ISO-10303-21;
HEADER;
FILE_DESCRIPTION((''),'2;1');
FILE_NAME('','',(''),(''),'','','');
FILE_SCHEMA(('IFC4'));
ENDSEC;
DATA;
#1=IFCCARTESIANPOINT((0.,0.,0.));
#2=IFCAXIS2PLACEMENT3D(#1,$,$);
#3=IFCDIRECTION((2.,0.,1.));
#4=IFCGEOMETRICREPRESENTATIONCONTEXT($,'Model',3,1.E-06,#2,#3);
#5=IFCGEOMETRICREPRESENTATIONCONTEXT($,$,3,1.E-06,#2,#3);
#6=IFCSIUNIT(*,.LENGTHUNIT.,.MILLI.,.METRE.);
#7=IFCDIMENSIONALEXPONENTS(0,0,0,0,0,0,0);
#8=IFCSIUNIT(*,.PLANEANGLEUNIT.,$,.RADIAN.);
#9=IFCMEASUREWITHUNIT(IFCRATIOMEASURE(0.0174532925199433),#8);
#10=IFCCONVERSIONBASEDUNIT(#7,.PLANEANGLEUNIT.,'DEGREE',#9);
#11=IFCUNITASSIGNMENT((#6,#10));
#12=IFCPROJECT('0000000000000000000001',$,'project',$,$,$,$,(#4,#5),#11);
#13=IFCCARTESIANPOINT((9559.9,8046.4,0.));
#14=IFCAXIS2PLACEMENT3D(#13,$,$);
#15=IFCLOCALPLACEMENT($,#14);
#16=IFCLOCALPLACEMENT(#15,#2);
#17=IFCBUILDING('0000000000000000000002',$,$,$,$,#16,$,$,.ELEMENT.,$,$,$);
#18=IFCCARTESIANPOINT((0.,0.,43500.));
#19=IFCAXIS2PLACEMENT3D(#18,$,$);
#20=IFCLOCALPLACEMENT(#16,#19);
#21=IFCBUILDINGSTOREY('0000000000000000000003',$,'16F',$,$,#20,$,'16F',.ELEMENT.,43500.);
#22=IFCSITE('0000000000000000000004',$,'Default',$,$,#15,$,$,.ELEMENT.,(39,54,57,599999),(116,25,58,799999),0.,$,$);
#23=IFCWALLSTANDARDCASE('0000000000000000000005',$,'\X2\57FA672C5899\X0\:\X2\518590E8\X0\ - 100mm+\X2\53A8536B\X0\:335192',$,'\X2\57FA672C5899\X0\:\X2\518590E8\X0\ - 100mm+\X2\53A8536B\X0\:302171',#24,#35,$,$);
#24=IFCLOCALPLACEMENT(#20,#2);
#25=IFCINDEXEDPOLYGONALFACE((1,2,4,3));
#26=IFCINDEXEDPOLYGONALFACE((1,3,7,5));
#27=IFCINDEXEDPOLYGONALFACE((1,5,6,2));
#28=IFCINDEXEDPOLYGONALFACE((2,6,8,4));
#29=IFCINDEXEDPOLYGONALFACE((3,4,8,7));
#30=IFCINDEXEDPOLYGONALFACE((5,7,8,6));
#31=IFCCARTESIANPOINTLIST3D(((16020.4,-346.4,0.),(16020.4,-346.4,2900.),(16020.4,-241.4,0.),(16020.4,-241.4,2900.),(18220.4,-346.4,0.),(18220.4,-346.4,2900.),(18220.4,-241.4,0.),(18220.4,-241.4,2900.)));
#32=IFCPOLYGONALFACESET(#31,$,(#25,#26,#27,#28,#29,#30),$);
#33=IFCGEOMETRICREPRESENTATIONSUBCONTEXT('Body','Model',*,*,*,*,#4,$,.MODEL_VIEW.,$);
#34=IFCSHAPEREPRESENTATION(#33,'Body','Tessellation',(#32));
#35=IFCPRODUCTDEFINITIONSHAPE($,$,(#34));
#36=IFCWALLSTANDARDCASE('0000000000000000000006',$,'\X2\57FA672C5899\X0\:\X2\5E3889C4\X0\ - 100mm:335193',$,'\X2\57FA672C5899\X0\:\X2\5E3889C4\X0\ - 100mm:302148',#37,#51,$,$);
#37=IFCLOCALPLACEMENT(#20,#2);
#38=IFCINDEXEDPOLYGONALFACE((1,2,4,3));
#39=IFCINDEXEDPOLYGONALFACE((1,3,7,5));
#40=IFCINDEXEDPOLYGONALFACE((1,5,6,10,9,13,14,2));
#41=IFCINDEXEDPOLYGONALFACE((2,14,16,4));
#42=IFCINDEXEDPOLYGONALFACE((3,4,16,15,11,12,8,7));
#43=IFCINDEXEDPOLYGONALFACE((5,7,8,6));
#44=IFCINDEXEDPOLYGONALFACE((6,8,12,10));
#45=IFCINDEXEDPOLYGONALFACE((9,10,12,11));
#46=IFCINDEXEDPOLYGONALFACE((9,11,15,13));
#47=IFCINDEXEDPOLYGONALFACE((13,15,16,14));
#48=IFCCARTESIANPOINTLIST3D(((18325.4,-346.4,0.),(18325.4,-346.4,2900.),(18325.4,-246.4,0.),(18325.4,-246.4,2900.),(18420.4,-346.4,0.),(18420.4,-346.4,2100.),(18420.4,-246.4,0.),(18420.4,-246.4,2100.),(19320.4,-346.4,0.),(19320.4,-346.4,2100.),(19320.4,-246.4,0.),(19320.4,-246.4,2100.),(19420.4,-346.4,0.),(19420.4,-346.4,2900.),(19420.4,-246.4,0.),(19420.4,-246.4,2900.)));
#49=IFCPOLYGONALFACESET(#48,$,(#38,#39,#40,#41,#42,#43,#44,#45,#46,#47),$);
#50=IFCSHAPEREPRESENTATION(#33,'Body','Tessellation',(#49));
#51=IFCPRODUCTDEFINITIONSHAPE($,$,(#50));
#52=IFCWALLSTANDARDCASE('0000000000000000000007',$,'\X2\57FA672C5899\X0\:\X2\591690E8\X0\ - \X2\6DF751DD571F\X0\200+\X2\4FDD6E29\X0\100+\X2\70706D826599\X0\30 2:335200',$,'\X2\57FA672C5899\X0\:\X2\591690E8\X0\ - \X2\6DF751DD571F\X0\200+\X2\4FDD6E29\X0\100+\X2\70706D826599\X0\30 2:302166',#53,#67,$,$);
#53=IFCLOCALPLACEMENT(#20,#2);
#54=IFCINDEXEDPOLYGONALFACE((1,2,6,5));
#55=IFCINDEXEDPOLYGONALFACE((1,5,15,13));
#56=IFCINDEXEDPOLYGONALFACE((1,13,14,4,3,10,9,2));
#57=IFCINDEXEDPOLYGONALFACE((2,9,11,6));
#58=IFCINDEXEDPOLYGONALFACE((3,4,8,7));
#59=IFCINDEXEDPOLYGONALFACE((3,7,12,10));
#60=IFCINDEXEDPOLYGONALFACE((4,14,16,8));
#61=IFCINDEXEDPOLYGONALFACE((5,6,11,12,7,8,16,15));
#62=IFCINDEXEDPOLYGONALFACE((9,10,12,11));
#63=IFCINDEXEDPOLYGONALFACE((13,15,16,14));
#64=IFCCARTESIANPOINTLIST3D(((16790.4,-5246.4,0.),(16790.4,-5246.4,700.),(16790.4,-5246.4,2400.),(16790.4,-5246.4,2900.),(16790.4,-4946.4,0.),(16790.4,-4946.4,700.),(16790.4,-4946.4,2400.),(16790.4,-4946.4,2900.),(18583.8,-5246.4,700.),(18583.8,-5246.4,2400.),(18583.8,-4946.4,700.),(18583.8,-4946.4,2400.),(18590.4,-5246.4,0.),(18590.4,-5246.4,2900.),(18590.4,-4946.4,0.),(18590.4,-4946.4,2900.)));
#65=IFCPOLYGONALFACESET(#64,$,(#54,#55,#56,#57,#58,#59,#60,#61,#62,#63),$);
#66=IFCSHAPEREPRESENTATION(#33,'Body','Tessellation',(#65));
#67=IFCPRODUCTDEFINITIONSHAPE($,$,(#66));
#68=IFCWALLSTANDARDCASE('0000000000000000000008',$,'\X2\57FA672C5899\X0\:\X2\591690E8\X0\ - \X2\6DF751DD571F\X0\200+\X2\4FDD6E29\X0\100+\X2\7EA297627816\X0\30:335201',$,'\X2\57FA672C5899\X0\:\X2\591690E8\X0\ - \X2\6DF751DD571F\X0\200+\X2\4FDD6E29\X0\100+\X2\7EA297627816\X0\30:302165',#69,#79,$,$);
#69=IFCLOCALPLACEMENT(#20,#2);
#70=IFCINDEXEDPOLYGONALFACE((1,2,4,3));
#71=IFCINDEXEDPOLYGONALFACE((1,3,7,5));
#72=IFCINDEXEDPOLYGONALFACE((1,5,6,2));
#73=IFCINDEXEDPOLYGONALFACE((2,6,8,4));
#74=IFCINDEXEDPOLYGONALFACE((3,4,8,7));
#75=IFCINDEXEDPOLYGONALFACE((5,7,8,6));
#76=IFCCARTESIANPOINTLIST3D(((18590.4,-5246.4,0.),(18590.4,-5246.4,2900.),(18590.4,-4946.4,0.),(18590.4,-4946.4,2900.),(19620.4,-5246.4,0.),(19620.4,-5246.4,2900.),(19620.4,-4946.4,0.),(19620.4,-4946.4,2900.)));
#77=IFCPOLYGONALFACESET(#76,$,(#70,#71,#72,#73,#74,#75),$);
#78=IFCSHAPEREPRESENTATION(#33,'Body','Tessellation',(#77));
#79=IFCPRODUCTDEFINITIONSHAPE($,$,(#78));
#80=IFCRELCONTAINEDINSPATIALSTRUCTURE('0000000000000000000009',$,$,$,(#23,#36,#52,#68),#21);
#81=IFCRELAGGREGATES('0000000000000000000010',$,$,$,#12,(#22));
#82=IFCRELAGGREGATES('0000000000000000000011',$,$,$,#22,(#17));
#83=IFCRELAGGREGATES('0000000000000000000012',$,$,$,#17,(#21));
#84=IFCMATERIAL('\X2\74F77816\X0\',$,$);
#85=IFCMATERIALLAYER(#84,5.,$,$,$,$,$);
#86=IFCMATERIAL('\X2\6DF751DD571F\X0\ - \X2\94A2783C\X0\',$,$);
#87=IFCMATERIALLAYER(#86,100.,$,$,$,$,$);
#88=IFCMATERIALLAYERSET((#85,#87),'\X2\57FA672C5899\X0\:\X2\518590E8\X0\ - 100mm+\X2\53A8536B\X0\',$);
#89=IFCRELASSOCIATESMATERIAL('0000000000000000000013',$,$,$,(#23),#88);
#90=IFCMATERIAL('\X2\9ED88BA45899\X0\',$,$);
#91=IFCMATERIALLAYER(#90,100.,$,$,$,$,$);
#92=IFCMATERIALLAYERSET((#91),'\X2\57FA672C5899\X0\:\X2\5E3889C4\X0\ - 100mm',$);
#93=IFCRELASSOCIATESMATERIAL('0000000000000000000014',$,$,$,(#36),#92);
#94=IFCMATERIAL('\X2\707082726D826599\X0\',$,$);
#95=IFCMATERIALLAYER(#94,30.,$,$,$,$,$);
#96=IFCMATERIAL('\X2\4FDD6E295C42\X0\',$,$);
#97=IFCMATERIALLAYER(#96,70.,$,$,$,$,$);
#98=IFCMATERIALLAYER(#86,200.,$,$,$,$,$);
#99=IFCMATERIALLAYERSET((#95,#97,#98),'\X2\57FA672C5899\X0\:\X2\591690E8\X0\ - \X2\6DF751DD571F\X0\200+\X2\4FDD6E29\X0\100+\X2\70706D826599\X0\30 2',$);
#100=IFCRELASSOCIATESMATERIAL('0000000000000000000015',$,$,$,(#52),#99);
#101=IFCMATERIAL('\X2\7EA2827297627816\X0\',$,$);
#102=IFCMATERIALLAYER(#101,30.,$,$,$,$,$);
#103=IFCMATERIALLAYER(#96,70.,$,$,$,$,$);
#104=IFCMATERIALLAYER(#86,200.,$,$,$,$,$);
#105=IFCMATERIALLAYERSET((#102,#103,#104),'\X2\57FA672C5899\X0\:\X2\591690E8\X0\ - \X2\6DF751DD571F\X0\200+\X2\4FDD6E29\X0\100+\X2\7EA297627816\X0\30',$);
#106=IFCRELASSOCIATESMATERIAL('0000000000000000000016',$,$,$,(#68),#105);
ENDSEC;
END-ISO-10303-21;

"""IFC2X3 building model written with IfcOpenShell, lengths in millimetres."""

from ifc_helpers import new_model, entity, si_unit, converted_unit, direction, frame, frame_2d, origin, place, context, subcontext, project, spatial, rectangle, extrude, material, layer, layer_set, layer_usage, element, save


model = new_model("IFC2X3")

# Units and contexts
model_context = context("Model", 3, precision=1e-06, world=origin(), true_north=direction((2.0, 0.0, 1.0)))
context_of_model = context(None, 3, precision=1e-06, world=origin(), true_north=direction((2.0, 0.0, 1.0)))
body_context = subcontext(model_context, "Body", "Model", "MODEL_VIEW")
ifc_project = project(units=[si_unit("LENGTHUNIT", "METRE", prefix="MILLI"), converted_unit("PLANEANGLEUNIT", "DEGREE", entity("IfcRatioMeasure", 0.0174532925199433), si_unit("PLANEANGLEUNIT", "RADIAN"), dimensions=[0, 0, 0, 0, 0, 0, 0])], contexts=[model_context, context_of_model])

# Site, building, storey
site_placement = place(None, frame((9559.9, 8046.4, 0.0)))
site = spatial("IfcSite", under=ifc_project, at=site_placement, Name="Default", CompositionType="ELEMENT", RefLatitude=(39, 54, 57, 599999), RefLongitude=(116, 25, 58, 799999), RefElevation=0.0)
building_placement = place(site_placement, origin())
building = spatial("IfcBuilding", under=site, at=building_placement, CompositionType="ELEMENT")
storey_placement = place(building_placement, frame((0.0, 0.0, 43500.0)))
storey = spatial("IfcBuildingStorey", under=building, at=storey_placement, Name="16F", LongName="16F", CompositionType="ELEMENT", Elevation=43500.0)

# Shared definitions
ifc_material_1 = material(Name="混凝土 - 钢砼")
ifc_material_2 = material(Name="红色面砖")
ifc_layer_1 = layer(ifc_material_2, 30.0)
ifc_material_3 = material(Name="保温层")
ifc_layer_2 = layer(ifc_material_3, 70.0)
ifc_layer_3 = layer(ifc_material_1, 200.0)
ifc_layer_set_1 = layer_set([ifc_layer_1, ifc_layer_2, ifc_layer_3], Name="基本墙:外部 - 混凝土200+保温100+红面砖30")

# Shared definitions
ifc_material_4 = material(Name="默认墙")
ifc_layer_4 = layer(ifc_material_4, 100.0)
ifc_layer_set_2 = layer_set([ifc_layer_4], Name="基本墙:常规 - 100mm")

# Shared definitions
ifc_material_5 = material(Name="瓷砖")
ifc_layer_5 = layer(ifc_material_5, 5.0)
ifc_layer_6 = layer(ifc_material_1, 100.0)
ifc_layer_set_3 = layer_set([ifc_layer_5, ifc_layer_6], Name="基本墙:内部 - 100mm+厨卫")

# Shared definitions
ifc_material_6 = material(Name="灰色涂料")
ifc_layer_7 = layer(ifc_material_6, 30.0)
ifc_layer_8 = layer(ifc_material_3, 70.0)
ifc_layer_9 = layer(ifc_material_1, 200.0)
ifc_layer_set_4 = layer_set([ifc_layer_7, ifc_layer_8, ifc_layer_9], Name="基本墙:外部 - 混凝土200+保温100+灰涂料30 2")

# Wall
ifc_layer_usage_1 = layer_usage(ifc_layer_set_3, "AXIS2", "NEGATIVE", 52.5)
wall_1_placement = place(storey_placement, frame((16020.4, -293.9, 0.0)))
element("IfcWallStandardCase", 1, at=wall_1_placement, inside=storey, material=ifc_layer_usage_1, Name="基本墙:内部 - 100mm+厨卫:335192", ObjectType="基本墙:内部 - 100mm+厨卫:302171", context=body_context, shape_type="SweptSolid", body=[
    extrude(rectangle(XDim=2200.0, YDim=105.0, at=frame_2d((1100.0, 0.0), x_axis=(-1.0, 0.0))), origin(), (0.0, 0.0, 1.0), 2900.0),
])

# Walls, openings
ifc_layer_usage_2 = layer_usage(ifc_layer_set_2, "AXIS2", "NEGATIVE", 50.0)
wall_2_placement = place(storey_placement, frame((18325.4, -296.4, 0.0)))
wall_2 = element("IfcWallStandardCase", 2, at=wall_2_placement, inside=storey, material=ifc_layer_usage_2, Name="基本墙:常规 - 100mm:335193", ObjectType="基本墙:常规 - 100mm:302148", context=body_context, shape_type="SweptSolid", body=[
    extrude(rectangle(XDim=1095.0, YDim=100.0, at=frame_2d((547.5, 0.0), x_axis=(-1.0, 0.0))), origin(), (0.0, 0.0, 1.0), 2900.0),
])
opening_1_placement = place(wall_2_placement, frame((995.0, 50.0, 0.0)))
element("IfcOpeningElement", 3, at=opening_1_placement, cuts=wall_2, ObjectType="Opening", context=body_context, shape_type="SweptSolid", body=[
    extrude(rectangle(XDim=2100.0, YDim=900.0, at=frame_2d((1050.0, 450.0), x_axis=(1.0, 0.0))), frame((0.0, 0.0, 0.0), z_axis=(0.0, -1.0, 0.0), x_axis=(0.0, 0.0, 1.0)), (0.0, 0.0, 1.0), 100.0),
])
ifc_layer_usage_3 = layer_usage(ifc_layer_set_4, "AXIS2", "POSITIVE", -150.0)
wall_3_placement = place(storey_placement, frame((16790.4, -5096.4, 0.0)))
wall_3 = element("IfcWallStandardCase", 4, at=wall_3_placement, inside=storey, material=ifc_layer_usage_3, Name="基本墙:外部 - 混凝土200+保温100+灰涂料30 2:335200", ObjectType="基本墙:外部 - 混凝土200+保温100+灰涂料30 2:302166", context=body_context, shape_type="SweptSolid", body=[
    extrude(rectangle(XDim=1800.0, YDim=300.0, at=frame_2d((900.0, 0.0), x_axis=(-1.0, 0.0))), origin(), (0.0, 0.0, 1.0), 2900.0),
])
opening_2_placement = place(wall_3_placement, frame((1793.4, 150.0, 700.0)))
element("IfcOpeningElement", 5, at=opening_2_placement, cuts=wall_3, ObjectType="Opening", context=body_context, shape_type="SweptSolid", body=[
    extrude(rectangle(XDim=1700.0, YDim=1800.0, at=frame_2d((850.0, 900.0), x_axis=(1.0, 0.0))), frame((0.0, 0.0, 0.0), z_axis=(0.0, -1.0, 0.0), x_axis=(0.0, 0.0, 1.0)), (0.0, 0.0, 1.0), 300.0),
])

# Wall
ifc_layer_usage_4 = layer_usage(ifc_layer_set_1, "AXIS2", "POSITIVE", -150.0)
wall_4_placement = place(storey_placement, frame((18590.4, -5096.4, 0.0)))
element("IfcWallStandardCase", 6, at=wall_4_placement, inside=storey, material=ifc_layer_usage_4, Name="基本墙:外部 - 混凝土200+保温100+红面砖30:335201", ObjectType="基本墙:外部 - 混凝土200+保温100+红面砖30:302165", context=body_context, shape_type="SweptSolid", body=[
    extrude(rectangle(XDim=1030.0, YDim=300.0, at=frame_2d((515.0, 0.0), x_axis=(-1.0, 0.0))), origin(), (0.0, 0.0, 1.0), 2900.0),
])

save(model, "model.ifc")
